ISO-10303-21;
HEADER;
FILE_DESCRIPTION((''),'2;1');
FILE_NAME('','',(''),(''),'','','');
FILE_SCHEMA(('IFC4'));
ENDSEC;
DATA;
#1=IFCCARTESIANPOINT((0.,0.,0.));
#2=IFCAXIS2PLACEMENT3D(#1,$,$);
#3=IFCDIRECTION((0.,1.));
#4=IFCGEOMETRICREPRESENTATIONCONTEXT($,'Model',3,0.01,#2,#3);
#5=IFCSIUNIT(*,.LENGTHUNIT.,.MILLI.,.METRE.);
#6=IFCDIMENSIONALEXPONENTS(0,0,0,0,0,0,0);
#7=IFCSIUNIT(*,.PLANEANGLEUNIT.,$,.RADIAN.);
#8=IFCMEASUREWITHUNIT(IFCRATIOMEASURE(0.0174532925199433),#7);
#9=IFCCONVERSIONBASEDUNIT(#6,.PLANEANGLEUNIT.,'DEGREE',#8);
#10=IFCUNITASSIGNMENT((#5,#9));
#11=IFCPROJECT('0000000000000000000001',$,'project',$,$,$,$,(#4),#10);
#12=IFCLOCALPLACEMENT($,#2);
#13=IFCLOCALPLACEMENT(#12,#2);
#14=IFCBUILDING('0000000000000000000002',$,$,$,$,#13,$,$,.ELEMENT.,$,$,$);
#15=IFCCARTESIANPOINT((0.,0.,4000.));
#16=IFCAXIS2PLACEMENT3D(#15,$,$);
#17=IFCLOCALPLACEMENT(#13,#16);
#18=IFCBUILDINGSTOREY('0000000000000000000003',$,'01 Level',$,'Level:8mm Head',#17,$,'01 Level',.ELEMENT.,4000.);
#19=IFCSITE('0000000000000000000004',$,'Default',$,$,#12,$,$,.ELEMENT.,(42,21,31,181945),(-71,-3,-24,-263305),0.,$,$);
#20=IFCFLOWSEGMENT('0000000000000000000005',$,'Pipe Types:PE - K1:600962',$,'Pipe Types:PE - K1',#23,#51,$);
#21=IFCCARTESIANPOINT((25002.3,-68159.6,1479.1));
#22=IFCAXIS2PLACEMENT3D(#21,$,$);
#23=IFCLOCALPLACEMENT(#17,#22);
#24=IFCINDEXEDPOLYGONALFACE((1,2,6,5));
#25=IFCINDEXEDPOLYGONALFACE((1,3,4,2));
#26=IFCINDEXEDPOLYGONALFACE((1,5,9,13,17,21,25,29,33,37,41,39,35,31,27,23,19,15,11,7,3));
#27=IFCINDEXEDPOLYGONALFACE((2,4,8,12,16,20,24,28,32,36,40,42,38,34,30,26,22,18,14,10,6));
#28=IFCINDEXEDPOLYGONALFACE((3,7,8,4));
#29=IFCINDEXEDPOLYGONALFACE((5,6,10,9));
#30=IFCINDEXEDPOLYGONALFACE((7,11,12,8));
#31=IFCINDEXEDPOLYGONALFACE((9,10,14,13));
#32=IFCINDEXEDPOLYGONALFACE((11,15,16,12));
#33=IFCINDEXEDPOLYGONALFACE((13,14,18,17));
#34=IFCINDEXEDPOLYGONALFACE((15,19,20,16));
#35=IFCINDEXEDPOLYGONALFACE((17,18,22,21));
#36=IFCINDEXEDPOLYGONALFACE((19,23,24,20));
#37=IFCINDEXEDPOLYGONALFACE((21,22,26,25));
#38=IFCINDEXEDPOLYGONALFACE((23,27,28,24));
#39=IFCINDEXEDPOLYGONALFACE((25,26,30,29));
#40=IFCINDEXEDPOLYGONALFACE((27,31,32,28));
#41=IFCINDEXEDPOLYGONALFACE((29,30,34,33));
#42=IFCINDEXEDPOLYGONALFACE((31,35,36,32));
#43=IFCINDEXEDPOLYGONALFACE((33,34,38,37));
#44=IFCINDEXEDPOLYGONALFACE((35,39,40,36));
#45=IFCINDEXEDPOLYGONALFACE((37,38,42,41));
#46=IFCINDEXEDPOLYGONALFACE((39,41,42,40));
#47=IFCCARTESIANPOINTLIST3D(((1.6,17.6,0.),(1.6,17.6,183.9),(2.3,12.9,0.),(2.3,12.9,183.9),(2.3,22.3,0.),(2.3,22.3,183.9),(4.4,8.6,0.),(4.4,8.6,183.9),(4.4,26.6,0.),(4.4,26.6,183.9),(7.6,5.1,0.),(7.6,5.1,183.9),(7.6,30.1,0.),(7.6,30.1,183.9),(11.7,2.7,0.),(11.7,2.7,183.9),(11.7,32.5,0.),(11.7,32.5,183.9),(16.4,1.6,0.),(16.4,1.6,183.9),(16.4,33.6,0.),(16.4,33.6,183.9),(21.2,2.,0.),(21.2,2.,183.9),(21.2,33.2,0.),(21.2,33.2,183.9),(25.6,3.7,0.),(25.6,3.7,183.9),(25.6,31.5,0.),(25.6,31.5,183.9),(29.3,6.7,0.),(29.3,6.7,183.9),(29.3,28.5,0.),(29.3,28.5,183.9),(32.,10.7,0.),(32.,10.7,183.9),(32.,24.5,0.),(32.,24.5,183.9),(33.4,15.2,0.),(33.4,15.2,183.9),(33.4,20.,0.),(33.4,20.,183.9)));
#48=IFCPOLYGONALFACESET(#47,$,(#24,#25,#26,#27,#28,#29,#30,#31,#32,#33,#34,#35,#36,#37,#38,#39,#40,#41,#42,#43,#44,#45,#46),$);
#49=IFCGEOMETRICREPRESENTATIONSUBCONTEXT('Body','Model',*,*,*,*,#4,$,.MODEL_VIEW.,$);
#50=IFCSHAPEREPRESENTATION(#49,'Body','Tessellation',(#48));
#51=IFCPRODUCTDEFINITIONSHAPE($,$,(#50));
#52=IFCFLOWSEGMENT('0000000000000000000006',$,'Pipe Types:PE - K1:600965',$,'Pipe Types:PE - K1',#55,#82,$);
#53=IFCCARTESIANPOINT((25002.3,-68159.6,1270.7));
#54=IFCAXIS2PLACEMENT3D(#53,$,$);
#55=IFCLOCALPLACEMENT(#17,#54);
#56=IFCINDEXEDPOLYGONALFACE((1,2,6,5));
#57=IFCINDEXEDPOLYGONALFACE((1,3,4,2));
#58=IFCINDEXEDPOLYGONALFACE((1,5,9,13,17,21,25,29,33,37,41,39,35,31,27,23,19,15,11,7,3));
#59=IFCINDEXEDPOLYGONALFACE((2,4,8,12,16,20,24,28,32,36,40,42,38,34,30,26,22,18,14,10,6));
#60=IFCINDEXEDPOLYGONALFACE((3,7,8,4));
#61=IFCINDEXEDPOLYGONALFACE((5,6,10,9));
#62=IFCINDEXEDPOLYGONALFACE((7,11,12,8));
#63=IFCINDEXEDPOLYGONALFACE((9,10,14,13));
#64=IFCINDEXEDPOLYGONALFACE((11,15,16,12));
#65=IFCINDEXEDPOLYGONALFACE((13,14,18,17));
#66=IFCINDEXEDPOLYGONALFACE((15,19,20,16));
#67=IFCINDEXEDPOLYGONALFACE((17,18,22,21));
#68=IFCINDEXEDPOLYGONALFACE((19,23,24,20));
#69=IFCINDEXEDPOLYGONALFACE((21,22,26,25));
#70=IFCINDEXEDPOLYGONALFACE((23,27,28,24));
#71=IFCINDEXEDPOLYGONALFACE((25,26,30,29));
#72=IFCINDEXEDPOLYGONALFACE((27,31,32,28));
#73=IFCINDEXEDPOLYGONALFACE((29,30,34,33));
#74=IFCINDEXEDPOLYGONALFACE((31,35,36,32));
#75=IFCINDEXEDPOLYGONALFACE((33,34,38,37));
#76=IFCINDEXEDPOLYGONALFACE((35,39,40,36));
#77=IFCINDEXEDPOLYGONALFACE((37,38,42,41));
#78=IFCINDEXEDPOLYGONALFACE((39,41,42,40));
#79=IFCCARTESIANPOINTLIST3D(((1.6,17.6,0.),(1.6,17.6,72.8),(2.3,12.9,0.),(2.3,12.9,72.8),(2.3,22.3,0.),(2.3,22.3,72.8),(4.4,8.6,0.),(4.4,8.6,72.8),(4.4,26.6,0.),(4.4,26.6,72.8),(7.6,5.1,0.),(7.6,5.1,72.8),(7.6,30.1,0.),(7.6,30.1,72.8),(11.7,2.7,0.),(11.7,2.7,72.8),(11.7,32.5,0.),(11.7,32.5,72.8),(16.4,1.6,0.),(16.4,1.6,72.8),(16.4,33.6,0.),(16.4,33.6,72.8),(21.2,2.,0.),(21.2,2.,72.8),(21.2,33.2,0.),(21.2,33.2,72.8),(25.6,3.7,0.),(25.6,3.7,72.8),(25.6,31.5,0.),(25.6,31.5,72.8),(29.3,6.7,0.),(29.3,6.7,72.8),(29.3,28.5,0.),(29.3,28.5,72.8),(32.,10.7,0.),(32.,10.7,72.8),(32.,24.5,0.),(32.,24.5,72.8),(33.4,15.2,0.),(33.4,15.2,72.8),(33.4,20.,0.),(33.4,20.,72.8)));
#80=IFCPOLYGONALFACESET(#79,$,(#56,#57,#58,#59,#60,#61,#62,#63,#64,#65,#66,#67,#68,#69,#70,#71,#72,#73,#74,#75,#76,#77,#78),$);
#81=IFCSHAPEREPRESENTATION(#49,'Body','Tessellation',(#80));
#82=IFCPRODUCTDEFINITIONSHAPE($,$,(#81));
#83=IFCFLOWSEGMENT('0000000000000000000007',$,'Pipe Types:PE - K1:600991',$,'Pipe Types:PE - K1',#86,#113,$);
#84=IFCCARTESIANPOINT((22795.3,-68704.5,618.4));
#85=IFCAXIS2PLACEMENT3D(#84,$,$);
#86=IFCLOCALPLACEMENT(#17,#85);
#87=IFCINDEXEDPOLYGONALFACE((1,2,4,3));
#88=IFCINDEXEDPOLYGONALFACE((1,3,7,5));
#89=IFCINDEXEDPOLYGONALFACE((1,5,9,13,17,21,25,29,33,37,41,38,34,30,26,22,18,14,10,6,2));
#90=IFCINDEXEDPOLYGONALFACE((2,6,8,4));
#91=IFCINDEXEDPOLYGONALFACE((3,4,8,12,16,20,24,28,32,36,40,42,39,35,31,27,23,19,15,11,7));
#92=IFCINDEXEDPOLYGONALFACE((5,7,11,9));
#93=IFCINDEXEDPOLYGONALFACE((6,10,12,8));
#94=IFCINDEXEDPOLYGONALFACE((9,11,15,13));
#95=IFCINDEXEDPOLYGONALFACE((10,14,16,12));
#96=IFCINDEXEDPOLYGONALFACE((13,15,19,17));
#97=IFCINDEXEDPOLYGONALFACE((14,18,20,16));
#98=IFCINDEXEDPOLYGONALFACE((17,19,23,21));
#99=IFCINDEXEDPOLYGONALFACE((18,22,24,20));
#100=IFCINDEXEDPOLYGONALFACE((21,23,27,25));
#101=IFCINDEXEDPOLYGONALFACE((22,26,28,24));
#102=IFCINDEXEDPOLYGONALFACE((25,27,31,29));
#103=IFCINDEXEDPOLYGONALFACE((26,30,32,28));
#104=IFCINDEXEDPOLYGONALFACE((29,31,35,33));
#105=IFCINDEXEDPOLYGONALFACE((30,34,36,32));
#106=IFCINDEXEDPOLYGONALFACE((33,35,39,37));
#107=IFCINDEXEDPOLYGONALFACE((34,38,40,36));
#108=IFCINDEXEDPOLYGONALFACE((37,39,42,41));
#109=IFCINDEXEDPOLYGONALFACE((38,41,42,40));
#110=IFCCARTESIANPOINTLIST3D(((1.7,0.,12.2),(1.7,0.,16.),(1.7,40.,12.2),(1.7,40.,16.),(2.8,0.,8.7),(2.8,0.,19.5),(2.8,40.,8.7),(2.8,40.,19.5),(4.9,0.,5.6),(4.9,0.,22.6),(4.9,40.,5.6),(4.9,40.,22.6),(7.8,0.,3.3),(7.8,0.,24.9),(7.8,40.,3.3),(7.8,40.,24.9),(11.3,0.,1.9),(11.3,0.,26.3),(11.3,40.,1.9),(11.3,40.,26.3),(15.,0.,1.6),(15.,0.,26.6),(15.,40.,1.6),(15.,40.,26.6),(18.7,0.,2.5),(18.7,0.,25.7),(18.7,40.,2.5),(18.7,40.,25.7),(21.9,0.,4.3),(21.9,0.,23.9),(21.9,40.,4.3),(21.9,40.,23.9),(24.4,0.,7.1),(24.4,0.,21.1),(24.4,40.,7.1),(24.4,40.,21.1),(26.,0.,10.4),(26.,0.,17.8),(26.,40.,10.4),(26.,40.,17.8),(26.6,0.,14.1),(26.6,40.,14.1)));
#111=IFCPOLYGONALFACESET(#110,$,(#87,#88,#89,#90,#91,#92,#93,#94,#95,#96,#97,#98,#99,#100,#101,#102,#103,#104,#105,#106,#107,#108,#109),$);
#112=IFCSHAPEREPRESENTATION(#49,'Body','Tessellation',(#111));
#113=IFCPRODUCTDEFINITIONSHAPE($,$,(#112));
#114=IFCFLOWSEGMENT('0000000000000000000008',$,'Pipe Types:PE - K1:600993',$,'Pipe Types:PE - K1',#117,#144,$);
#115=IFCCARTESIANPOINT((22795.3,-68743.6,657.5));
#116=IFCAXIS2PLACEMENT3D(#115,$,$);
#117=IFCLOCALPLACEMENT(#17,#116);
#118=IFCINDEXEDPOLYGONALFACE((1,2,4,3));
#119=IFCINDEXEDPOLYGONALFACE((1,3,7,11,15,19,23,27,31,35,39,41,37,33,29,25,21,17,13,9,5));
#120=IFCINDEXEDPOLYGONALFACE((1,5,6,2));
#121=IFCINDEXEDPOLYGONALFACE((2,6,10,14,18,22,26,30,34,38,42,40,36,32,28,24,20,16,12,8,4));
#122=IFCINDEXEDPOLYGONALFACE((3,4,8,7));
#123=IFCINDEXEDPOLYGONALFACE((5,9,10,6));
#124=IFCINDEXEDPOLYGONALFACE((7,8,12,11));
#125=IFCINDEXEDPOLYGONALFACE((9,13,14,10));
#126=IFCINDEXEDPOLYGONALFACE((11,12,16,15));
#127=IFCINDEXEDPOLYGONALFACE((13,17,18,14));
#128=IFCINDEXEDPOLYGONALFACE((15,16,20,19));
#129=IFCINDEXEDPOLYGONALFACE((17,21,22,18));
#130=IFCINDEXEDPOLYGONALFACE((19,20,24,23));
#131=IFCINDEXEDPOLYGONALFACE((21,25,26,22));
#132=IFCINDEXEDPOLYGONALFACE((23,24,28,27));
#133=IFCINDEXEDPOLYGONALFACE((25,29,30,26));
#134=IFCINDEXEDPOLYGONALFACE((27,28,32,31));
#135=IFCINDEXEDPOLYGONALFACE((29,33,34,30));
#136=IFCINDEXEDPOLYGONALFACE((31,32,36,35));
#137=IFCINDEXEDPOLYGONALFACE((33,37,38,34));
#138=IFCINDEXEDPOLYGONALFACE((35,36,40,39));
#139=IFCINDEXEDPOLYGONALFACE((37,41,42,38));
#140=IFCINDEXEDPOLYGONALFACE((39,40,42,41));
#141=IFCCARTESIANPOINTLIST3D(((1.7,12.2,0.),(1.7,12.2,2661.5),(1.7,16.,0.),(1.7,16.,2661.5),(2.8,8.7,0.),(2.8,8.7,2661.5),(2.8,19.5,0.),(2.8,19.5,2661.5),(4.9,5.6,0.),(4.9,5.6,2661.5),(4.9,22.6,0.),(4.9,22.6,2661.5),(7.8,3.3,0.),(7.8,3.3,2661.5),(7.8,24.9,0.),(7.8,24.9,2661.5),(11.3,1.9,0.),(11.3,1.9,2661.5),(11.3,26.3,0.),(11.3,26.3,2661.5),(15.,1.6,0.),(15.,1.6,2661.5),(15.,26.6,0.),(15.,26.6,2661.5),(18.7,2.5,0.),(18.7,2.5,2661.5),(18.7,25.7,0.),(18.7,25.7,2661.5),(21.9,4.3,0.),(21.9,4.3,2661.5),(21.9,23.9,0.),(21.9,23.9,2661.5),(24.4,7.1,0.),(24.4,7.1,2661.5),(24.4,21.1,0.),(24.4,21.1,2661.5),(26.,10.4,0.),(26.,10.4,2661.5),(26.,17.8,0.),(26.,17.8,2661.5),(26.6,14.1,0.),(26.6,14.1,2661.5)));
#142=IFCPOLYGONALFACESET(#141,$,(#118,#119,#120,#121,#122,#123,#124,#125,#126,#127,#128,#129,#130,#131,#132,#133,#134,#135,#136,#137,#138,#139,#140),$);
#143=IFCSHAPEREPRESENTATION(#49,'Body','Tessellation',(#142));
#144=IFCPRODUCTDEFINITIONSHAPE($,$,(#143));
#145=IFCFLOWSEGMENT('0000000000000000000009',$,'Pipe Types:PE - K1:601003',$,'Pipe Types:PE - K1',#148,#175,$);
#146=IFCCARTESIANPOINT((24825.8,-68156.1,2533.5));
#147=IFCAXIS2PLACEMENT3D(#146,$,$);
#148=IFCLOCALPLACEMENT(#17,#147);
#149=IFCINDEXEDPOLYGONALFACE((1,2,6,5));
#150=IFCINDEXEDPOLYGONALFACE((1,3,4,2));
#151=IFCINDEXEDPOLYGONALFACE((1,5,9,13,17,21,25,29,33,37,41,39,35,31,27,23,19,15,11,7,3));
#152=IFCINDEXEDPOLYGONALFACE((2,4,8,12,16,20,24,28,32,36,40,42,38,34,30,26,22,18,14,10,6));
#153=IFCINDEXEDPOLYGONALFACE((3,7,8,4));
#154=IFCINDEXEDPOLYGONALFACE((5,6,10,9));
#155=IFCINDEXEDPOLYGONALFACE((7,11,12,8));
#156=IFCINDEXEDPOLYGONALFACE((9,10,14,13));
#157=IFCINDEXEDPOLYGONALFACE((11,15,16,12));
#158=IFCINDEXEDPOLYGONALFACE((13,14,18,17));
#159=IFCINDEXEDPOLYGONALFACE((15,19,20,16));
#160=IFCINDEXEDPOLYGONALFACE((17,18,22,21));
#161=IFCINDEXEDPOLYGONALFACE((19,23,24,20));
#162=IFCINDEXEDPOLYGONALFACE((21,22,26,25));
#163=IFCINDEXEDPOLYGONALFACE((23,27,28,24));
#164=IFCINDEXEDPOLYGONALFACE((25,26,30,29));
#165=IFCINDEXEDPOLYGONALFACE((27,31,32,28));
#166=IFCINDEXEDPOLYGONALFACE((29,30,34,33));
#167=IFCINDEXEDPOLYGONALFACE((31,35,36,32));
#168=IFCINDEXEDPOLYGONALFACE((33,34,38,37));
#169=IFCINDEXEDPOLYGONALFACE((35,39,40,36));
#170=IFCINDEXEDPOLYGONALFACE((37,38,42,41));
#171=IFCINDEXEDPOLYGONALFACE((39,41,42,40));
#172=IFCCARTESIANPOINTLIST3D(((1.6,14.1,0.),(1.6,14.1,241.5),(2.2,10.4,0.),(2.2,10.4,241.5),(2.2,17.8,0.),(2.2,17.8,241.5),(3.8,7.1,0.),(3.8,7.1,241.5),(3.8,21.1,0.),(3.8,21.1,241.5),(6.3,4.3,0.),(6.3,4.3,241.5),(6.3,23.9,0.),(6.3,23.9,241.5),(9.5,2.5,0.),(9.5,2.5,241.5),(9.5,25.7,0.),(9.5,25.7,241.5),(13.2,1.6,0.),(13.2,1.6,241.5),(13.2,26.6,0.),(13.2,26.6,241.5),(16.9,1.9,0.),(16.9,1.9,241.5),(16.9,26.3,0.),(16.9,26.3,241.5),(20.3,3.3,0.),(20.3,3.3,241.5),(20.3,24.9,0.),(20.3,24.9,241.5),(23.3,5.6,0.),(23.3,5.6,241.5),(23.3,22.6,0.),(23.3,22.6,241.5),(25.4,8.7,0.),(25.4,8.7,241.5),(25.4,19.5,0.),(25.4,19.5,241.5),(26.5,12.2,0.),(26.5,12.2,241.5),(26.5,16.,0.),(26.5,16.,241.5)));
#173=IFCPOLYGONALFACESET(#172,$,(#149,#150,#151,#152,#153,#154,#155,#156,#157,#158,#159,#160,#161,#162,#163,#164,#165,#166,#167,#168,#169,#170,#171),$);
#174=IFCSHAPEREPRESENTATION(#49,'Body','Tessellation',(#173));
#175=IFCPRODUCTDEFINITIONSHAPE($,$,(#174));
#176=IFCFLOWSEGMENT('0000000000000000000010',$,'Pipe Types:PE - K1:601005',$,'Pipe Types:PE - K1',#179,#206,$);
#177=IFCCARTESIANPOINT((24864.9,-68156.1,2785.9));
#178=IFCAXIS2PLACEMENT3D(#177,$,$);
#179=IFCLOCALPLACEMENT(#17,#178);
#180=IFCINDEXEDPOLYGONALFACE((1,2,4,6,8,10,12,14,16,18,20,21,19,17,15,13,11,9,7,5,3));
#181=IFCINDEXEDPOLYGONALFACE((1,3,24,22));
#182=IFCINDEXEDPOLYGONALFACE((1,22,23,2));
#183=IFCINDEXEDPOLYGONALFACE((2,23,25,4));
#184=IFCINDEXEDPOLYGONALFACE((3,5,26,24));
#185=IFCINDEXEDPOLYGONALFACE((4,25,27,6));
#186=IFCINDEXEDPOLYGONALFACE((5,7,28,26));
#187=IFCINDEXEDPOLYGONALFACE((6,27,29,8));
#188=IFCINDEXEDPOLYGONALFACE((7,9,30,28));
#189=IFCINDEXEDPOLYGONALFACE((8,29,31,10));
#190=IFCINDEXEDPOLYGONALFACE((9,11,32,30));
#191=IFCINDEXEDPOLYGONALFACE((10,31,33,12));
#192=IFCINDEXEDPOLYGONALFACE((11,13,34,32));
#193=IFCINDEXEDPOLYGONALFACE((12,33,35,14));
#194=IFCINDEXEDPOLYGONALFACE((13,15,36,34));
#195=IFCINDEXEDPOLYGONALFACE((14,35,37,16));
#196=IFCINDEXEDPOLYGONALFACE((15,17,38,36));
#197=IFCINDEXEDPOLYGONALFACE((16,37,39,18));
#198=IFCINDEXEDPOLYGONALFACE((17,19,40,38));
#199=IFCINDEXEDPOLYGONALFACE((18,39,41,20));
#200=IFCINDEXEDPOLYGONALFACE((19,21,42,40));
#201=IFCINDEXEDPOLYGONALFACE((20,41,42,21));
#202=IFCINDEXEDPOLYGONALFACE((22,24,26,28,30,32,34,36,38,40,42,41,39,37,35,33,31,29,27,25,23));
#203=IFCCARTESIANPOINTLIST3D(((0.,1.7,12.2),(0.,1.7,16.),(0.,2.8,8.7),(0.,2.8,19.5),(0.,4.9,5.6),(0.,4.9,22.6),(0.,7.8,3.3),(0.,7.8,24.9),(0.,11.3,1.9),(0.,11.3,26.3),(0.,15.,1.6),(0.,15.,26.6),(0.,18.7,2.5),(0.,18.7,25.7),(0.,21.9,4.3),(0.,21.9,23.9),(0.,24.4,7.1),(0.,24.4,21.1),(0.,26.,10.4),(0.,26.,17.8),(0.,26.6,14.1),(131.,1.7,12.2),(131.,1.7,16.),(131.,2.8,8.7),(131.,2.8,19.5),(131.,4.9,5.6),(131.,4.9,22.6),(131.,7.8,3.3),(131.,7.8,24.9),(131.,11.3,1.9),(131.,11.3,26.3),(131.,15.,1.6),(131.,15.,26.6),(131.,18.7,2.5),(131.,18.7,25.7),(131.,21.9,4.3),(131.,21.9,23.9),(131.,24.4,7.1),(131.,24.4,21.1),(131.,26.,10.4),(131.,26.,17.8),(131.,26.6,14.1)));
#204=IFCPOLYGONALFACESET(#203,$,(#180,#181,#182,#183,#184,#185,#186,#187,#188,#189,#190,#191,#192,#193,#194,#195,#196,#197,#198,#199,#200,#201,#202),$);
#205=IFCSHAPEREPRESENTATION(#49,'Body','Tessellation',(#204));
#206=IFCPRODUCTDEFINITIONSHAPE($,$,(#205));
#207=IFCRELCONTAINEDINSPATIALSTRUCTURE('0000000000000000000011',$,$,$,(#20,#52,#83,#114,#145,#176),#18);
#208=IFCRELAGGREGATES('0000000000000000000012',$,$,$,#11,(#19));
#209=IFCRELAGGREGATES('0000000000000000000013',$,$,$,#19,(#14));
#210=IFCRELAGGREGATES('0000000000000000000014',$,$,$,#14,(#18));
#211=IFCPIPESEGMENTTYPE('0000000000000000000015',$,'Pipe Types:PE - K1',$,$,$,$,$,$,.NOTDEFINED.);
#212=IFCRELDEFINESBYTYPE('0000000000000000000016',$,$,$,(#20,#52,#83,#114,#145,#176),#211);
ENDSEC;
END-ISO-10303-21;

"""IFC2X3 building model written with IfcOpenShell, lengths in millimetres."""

from ifc_helpers import new_model, entity, si_unit, converted_unit, direction, frame, frame_2d, origin, origin_2d_with_axis, place, context, subcontext, project, spatial, circle, extrude, type_object, element, save


model = new_model("IFC2X3")

# Units and contexts
model_context = context("Model", 3, precision=0.01, world=origin(), true_north=direction((0.0, 1.0)))
body_context = subcontext(model_context, "Body", "Model", "MODEL_VIEW")
ifc_project = project(units=[si_unit("LENGTHUNIT", "METRE", prefix="MILLI"), converted_unit("PLANEANGLEUNIT", "DEGREE", entity("IfcRatioMeasure", 0.0174532925199433), si_unit("PLANEANGLEUNIT", "RADIAN"), dimensions=[0, 0, 0, 0, 0, 0, 0])], contexts=[model_context])

# Site, building, storey
site_placement = place(None, origin())
site = spatial("IfcSite", under=ifc_project, at=site_placement, Name="Default", CompositionType="ELEMENT", RefLatitude=(42, 21, 31, 181945), RefLongitude=(-71, -3, -24, -263305), RefElevation=0.0)
building_placement = place(site_placement, origin())
building = spatial("IfcBuilding", under=site, at=building_placement, CompositionType="ELEMENT")
storey_placement = place(building_placement, frame((0.0, 0.0, 4000.0)))
storey = spatial("IfcBuildingStorey", under=building, at=storey_placement, Name="01 Level", ObjectType="Level:8mm Head", LongName="01 Level", CompositionType="ELEMENT", Elevation=4000.0)

# Flow segments
pipe_segment_type = type_object("IfcPipeSegmentType", Name="Pipe Types:PE - K1", PredefinedType="NOTDEFINED")
flow_segment_1_placement = place(storey_placement, frame((25002.3, -68159.6, 1479.1)))
element("IfcFlowSegment", 1, at=flow_segment_1_placement, inside=storey, type_object=pipe_segment_type, Name="Pipe Types:PE - K1:600962", ObjectType="Pipe Types:PE - K1", context=body_context, shape_type="SweptSolid", body=[
    extrude(circle(Radius=16.0, at=origin_2d_with_axis()), frame((17.6, 17.6, 0.0), z_axis=(0.0, 0.0, 1.0), x_axis=(-1.0, 0.0, 0.0)), (0.0, 0.0, 1.0), 183.9),
])
flow_segment_2_placement = place(storey_placement, frame((25002.3, -68159.6, 1270.7)))
element("IfcFlowSegment", 2, at=flow_segment_2_placement, inside=storey, type_object=pipe_segment_type, Name="Pipe Types:PE - K1:600965", ObjectType="Pipe Types:PE - K1", context=body_context, shape_type="SweptSolid", body=[
    extrude(circle(Radius=16.0, at=origin_2d_with_axis()), frame((17.6, 17.6, 0.0), z_axis=(0.0, 0.0, 1.0), x_axis=(-1.0, 0.0, 0.0)), (0.0, 0.0, 1.0), 72.8),
])
flow_segment_3_placement = place(storey_placement, frame((22795.3, -68704.5, 618.4)))
element("IfcFlowSegment", 3, at=flow_segment_3_placement, inside=storey, type_object=pipe_segment_type, Name="Pipe Types:PE - K1:600991", ObjectType="Pipe Types:PE - K1", context=body_context, shape_type="SweptSolid", body=[
    extrude(circle(Radius=12.5, at=origin_2d_with_axis()), frame((14.1, 0.0, 14.1), z_axis=(0.0, 1.0, 0.0), x_axis=(1.0, 0.0, 0.0)), (0.0, 0.0, 1.0), 40.0),
])
flow_segment_4_placement = place(storey_placement, frame((22795.3, -68743.6, 657.5)))
element("IfcFlowSegment", 4, at=flow_segment_4_placement, inside=storey, type_object=pipe_segment_type, Name="Pipe Types:PE - K1:600993", ObjectType="Pipe Types:PE - K1", context=body_context, shape_type="SweptSolid", body=[
    extrude(circle(Radius=12.5, at=frame_2d((0.0, 0.0), x_axis=(1.0, 0.0))), frame((14.1, 14.1, 0.0)), (0.0, 0.0, 1.0), 2661.5),
])
flow_segment_5_placement = place(storey_placement, frame((24825.8, -68156.1, 2533.5)))
element("IfcFlowSegment", 5, at=flow_segment_5_placement, inside=storey, type_object=pipe_segment_type, Name="Pipe Types:PE - K1:601003", ObjectType="Pipe Types:PE - K1", context=body_context, shape_type="SweptSolid", body=[
    extrude(circle(Radius=12.5, at=origin_2d_with_axis()), frame((14.1, 14.1, 0.0), z_axis=(0.0, 0.0, 1.0), x_axis=(-1.0, 0.0, 0.0)), (0.0, 0.0, 1.0), 241.5),
])
flow_segment_6_placement = place(storey_placement, frame((24864.9, -68156.1, 2785.9)))
element("IfcFlowSegment", 6, at=flow_segment_6_placement, inside=storey, type_object=pipe_segment_type, Name="Pipe Types:PE - K1:601005", ObjectType="Pipe Types:PE - K1", context=body_context, shape_type="SweptSolid", body=[
    extrude(circle(Radius=12.5, at=origin_2d_with_axis()), frame((0.0, 14.1, 14.1), z_axis=(1.0, 0.0, 0.0), x_axis=(0.0, 1.0, 0.0)), (0.0, 0.0, 1.0), 131.0),
])

save(model, "model.ifc")
